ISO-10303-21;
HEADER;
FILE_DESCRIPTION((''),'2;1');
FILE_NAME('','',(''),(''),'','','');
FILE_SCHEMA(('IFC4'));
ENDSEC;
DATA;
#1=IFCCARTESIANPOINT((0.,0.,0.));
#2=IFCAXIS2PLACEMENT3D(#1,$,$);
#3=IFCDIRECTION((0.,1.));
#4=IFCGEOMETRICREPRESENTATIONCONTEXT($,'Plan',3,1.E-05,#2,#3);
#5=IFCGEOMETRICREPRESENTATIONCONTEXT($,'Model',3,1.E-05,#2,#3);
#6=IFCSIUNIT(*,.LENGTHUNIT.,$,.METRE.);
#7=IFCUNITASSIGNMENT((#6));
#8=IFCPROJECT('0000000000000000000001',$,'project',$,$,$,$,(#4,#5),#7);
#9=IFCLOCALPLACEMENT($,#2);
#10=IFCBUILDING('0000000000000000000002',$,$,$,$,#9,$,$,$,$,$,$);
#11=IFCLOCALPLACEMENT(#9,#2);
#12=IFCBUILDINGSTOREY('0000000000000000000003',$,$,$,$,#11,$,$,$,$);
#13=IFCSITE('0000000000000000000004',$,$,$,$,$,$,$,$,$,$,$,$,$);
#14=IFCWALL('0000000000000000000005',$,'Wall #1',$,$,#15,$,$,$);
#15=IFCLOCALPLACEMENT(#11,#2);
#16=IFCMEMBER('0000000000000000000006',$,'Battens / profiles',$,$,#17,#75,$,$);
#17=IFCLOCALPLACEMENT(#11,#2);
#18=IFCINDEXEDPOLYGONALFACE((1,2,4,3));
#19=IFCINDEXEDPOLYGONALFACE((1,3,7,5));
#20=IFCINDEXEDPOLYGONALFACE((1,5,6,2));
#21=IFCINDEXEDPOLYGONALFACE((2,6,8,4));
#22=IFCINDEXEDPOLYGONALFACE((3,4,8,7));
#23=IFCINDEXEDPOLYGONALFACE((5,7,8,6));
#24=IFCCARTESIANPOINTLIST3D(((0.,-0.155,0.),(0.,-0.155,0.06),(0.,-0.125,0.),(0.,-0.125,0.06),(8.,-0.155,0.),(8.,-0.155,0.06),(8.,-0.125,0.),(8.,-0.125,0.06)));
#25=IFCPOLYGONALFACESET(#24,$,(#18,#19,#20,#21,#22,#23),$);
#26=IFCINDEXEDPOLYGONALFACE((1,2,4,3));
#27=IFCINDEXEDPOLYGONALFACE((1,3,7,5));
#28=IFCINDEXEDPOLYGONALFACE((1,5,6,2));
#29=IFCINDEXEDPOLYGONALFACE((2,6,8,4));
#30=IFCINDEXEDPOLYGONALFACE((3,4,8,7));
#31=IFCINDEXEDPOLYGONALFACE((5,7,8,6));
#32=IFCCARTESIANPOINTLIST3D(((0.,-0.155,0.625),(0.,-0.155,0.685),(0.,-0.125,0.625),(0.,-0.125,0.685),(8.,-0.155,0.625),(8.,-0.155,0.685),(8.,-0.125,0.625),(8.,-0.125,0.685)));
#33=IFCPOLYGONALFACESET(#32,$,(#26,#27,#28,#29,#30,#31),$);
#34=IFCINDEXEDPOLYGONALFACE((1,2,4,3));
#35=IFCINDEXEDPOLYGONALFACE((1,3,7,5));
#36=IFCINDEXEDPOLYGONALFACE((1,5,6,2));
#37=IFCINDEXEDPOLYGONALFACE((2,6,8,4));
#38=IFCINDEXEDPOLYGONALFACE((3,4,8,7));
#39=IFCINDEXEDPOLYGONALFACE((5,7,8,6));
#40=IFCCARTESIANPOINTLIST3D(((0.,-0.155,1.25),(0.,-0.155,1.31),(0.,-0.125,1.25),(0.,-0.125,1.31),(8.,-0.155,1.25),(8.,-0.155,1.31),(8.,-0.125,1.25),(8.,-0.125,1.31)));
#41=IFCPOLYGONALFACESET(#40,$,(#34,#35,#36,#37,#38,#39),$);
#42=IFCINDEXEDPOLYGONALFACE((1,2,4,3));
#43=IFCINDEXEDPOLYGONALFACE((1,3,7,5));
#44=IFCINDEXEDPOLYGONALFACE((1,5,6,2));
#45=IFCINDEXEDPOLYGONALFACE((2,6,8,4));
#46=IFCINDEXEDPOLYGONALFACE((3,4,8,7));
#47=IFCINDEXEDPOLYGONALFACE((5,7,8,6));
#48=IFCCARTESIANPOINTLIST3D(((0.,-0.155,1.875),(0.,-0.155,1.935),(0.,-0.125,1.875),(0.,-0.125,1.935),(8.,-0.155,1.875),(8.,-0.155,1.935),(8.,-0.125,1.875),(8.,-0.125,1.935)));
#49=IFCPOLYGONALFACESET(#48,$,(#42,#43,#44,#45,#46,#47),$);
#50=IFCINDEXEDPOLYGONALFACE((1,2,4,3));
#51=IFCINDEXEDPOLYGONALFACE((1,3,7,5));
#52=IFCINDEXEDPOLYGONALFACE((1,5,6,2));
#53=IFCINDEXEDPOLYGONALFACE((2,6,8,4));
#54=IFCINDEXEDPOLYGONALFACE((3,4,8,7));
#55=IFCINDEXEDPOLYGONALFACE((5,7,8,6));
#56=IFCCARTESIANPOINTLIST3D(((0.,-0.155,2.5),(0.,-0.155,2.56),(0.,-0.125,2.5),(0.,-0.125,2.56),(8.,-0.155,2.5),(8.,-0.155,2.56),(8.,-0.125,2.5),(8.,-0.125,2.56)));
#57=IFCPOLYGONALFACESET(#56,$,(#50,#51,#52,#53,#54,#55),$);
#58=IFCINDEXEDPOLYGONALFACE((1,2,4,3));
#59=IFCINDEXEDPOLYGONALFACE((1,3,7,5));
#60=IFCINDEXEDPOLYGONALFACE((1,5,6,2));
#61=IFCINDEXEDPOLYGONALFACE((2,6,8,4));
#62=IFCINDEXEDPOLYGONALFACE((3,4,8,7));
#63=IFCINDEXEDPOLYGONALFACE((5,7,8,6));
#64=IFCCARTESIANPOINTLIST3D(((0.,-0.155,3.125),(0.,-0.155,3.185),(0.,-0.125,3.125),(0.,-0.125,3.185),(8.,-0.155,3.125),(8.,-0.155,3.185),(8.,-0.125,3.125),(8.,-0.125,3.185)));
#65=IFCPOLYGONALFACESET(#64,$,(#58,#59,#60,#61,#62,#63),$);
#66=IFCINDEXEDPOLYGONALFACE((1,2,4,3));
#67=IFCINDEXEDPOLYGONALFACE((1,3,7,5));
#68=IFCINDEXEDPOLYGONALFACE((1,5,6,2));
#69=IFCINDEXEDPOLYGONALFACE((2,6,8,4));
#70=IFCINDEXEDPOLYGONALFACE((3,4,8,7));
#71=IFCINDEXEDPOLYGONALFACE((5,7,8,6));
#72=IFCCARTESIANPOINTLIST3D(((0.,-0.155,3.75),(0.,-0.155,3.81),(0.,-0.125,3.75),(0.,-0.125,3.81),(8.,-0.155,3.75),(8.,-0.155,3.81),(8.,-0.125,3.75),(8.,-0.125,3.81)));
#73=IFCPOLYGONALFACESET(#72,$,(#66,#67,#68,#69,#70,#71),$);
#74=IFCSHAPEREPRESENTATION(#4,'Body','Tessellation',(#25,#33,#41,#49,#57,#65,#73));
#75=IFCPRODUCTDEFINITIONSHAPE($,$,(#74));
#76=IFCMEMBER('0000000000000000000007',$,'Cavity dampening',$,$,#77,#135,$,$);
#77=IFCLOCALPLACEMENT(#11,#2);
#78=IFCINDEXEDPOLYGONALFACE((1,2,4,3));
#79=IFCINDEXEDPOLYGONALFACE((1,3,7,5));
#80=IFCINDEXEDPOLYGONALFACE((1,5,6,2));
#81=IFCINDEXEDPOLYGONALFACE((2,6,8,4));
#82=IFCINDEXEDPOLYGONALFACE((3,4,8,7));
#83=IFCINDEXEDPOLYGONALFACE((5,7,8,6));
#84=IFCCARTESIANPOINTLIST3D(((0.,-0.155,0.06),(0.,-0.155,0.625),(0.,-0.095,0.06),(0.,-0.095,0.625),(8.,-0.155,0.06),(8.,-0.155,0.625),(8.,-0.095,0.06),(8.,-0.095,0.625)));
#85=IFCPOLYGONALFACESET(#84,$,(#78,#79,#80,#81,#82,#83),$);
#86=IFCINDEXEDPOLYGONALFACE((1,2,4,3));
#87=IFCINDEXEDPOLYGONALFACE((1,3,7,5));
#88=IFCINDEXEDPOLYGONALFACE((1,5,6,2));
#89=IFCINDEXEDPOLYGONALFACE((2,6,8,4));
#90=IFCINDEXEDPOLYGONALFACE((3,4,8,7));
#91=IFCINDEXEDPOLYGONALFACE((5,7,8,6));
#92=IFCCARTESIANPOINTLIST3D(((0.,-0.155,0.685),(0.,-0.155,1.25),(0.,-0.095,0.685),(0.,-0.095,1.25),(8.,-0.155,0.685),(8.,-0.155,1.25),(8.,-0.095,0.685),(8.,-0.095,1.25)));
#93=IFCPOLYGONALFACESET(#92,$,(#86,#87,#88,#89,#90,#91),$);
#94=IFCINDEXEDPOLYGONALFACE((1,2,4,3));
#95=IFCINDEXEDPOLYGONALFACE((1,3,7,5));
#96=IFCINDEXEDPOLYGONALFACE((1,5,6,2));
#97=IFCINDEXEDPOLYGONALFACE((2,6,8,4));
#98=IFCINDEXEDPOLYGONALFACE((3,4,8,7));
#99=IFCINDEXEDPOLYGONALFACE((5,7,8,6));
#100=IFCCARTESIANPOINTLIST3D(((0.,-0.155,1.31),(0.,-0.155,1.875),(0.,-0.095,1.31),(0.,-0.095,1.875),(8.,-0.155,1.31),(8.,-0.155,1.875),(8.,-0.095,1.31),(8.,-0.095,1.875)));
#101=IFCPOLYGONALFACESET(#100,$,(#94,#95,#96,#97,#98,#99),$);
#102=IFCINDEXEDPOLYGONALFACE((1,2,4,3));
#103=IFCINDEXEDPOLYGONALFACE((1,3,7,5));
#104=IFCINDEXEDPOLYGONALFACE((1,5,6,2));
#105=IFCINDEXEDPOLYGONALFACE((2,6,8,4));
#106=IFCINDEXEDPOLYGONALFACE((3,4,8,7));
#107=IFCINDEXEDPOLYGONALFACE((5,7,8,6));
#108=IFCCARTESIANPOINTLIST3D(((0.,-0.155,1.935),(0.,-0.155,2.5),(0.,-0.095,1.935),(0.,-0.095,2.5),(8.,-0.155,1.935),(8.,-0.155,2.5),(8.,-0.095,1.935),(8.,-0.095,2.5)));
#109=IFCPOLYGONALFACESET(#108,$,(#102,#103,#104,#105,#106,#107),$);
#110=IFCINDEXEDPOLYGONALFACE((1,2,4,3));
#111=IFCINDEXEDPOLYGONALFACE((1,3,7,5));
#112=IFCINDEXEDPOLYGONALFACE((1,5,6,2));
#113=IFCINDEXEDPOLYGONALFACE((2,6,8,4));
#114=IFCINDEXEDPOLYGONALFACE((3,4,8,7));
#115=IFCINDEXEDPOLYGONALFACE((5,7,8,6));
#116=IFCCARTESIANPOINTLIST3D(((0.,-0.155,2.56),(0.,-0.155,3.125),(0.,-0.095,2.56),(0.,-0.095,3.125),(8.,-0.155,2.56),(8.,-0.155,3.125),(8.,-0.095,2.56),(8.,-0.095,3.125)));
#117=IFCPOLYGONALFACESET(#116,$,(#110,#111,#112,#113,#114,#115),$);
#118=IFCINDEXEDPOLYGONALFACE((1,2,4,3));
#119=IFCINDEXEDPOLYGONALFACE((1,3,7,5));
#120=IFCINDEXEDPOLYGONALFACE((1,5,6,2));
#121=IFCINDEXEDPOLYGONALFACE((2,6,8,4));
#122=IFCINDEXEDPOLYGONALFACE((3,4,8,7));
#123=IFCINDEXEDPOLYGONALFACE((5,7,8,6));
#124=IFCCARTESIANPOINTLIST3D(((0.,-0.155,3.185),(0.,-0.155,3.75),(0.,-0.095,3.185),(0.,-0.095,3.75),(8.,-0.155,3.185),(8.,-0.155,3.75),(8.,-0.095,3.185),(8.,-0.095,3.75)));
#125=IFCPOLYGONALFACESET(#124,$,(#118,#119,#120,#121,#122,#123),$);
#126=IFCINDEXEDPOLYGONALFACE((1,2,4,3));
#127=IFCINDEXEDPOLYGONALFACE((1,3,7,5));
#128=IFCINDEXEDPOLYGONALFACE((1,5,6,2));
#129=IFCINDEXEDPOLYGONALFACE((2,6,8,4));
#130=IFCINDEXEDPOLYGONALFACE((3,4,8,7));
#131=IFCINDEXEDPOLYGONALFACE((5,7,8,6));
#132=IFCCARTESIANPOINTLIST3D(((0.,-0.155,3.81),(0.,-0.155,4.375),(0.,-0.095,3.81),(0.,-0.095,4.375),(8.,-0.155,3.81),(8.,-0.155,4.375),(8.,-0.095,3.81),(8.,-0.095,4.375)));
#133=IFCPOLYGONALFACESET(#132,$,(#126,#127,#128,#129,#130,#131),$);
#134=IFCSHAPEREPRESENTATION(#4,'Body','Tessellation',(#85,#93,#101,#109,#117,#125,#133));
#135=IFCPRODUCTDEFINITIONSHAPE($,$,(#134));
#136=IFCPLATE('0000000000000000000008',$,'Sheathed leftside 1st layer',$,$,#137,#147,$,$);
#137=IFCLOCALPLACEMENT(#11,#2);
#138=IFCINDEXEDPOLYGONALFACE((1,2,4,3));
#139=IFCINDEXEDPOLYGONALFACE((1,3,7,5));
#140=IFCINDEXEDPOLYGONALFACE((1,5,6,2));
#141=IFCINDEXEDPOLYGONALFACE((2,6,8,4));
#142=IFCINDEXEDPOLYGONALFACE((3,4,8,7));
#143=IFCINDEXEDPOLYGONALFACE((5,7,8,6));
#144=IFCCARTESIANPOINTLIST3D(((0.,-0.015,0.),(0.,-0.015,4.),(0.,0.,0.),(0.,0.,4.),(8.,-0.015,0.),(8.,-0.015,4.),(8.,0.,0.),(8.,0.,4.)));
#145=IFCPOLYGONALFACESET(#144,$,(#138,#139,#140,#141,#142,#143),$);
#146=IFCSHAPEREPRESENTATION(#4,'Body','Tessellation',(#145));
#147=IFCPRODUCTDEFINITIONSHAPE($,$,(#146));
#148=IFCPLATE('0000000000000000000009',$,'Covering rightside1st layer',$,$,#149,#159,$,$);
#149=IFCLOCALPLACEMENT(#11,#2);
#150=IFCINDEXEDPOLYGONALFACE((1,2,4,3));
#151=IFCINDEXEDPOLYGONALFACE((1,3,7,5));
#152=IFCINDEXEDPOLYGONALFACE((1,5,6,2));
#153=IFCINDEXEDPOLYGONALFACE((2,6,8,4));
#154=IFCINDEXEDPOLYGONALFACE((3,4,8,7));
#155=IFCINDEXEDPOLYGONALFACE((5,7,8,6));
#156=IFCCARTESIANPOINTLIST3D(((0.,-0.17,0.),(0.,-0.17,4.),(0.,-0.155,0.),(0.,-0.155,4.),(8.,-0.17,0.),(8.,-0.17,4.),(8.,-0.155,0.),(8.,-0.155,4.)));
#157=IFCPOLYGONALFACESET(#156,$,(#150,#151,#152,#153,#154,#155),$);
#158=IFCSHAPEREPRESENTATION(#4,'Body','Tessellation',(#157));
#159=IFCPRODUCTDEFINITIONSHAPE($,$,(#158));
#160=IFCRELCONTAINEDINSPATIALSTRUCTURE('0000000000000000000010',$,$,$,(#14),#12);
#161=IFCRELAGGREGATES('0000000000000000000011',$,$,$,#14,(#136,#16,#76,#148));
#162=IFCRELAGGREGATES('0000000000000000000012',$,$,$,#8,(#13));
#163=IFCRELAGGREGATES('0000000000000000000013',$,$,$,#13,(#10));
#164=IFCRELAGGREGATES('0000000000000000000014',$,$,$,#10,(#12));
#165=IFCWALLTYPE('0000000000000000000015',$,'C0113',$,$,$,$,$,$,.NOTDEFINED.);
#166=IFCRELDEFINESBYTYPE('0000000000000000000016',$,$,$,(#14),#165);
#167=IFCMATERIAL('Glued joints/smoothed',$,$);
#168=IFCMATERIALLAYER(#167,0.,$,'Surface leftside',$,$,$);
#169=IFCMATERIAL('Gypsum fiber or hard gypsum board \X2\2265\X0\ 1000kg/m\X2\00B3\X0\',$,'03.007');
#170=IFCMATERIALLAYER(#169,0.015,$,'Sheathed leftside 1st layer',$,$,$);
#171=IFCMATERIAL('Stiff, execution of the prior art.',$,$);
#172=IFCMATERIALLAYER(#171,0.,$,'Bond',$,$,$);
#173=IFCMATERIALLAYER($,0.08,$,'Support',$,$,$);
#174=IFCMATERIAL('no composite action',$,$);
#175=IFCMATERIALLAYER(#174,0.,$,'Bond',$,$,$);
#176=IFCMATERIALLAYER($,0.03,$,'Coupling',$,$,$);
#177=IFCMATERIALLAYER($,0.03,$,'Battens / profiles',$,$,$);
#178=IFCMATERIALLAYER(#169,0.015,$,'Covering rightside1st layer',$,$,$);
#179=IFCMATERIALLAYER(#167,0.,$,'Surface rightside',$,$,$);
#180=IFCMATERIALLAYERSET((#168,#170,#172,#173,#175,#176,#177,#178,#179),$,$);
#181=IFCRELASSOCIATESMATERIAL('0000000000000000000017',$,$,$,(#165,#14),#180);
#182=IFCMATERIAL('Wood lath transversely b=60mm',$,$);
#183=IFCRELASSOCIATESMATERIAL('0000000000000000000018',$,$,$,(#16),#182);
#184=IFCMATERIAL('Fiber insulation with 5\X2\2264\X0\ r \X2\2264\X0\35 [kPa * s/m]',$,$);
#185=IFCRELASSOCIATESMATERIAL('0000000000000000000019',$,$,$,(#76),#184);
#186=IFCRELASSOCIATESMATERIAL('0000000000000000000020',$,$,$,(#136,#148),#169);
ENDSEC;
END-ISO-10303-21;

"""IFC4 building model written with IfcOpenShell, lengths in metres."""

from ifc_helpers import new_model, si_unit, direction, frame, frame_2d, origin, origin_with_axes, place, context, project, spatial, rectangle, extrude, material, layer, layer_set, type_object, element, aggregate, save


model = new_model("IFC4")

# Units and contexts
plan_context = context("Plan", 3, precision=1e-05, world=origin(), true_north=direction((0.0, 1.0)))
model_context = context("Model", 3, precision=1e-05, world=origin(), true_north=direction((0.0, 1.0)))
ifc_project = project(units=[si_unit("LENGTHUNIT", "METRE")], contexts=[plan_context, model_context])

# Site, building, storey
site = spatial("IfcSite", under=ifc_project)
building_placement = place(None, origin())
building = spatial("IfcBuilding", under=site, at=building_placement)
storey_placement = place(building_placement, origin())
storey = spatial("IfcBuildingStorey", under=building, at=storey_placement)

# Wall, members, plates
ifc_material_1 = material(Name="Glued joints/smoothed")
ifc_layer_1 = layer(ifc_material_1, 0.0, Name="Surface leftside")
ifc_material_2 = material(Name="Gypsum fiber or hard gypsum board ≥ 1000kg/m³", Category="03.007")
ifc_layer_2 = layer(ifc_material_2, 0.015, Name="Sheathed leftside 1st layer")
ifc_material_3 = material(Name="Stiff, execution of the prior art.")
ifc_layer_3 = layer(ifc_material_3, 0.0, Name="Bond")
ifc_layer_4 = layer(None, 0.08, Name="Support")
ifc_material_4 = material(Name="no composite action")
ifc_layer_5 = layer(ifc_material_4, 0.0, Name="Bond")
ifc_layer_6 = layer(None, 0.03, Name="Coupling")
ifc_layer_7 = layer(None, 0.03, Name="Battens / profiles")
ifc_layer_8 = layer(ifc_material_2, 0.015, Name="Covering rightside1st layer")
ifc_layer_9 = layer(ifc_material_1, 0.0, Name="Surface rightside")
ifc_layer_set = layer_set([ifc_layer_1, ifc_layer_2, ifc_layer_3, ifc_layer_4, ifc_layer_5, ifc_layer_6, ifc_layer_7, ifc_layer_8, ifc_layer_9])
wall_type = type_object("IfcWallType", Name="C0113", PredefinedType="NOTDEFINED", material=ifc_layer_set)
wall_placement = place(None, frame((0.0, 0.0, 0.0), z_axis=(0.0, -1.0, 0.0), x_axis=(1.0, 0.0, 0.0)))
wall = element("IfcWall", 1, at=wall_placement, inside=storey, type_object=wall_type, material=ifc_layer_set, Name="Wall #1")
ifc_material_5 = material(Name="Wood lath transversely b=60mm")
member_1_placement = place(wall_placement, origin())
member_1 = element("IfcMember", 2, at=member_1_placement, material=ifc_material_5, Name="Battens / profiles", context=plan_context, shape_type="SweptSolid", body=[
    extrude(rectangle(XDim=0.06, YDim=0.03, at=frame_2d((0.03, 0.015), x_axis=(1.0, 0.0))), frame((0.0, 0.0, 0.125), z_axis=(1.0, 0.0, 0.0), x_axis=(0.0, 1.0, 0.0)), (0.0, 0.0, 1.0), 8.0),
    extrude(rectangle(XDim=0.06, YDim=0.03, at=frame_2d((0.03, 0.015), x_axis=(1.0, 0.0))), frame((0.0, 0.625, 0.125), z_axis=(1.0, 0.0, 0.0), x_axis=(0.0, 1.0, 0.0)), (0.0, 0.0, 1.0), 8.0),
    extrude(rectangle(XDim=0.06, YDim=0.03, at=frame_2d((0.03, 0.015), x_axis=(1.0, 0.0))), frame((0.0, 1.25, 0.125), z_axis=(1.0, 0.0, 0.0), x_axis=(0.0, 1.0, 0.0)), (0.0, 0.0, 1.0), 8.0),
    extrude(rectangle(XDim=0.06, YDim=0.03, at=frame_2d((0.03, 0.015), x_axis=(1.0, 0.0))), frame((0.0, 1.875, 0.125), z_axis=(1.0, 0.0, 0.0), x_axis=(0.0, 1.0, 0.0)), (0.0, 0.0, 1.0), 8.0),
    extrude(rectangle(XDim=0.06, YDim=0.03, at=frame_2d((0.03, 0.015), x_axis=(1.0, 0.0))), frame((0.0, 2.5, 0.125), z_axis=(1.0, 0.0, 0.0), x_axis=(0.0, 1.0, 0.0)), (0.0, 0.0, 1.0), 8.0),
    extrude(rectangle(XDim=0.06, YDim=0.03, at=frame_2d((0.03, 0.015), x_axis=(1.0, 0.0))), frame((0.0, 3.125, 0.125), z_axis=(1.0, 0.0, 0.0), x_axis=(0.0, 1.0, 0.0)), (0.0, 0.0, 1.0), 8.0),
    extrude(rectangle(XDim=0.06, YDim=0.03, at=frame_2d((0.03, 0.015), x_axis=(1.0, 0.0))), frame((0.0, 3.75, 0.125), z_axis=(1.0, 0.0, 0.0), x_axis=(0.0, 1.0, 0.0)), (0.0, 0.0, 1.0), 8.0),
])
ifc_material_6 = material(Name="Fiber insulation with 5≤ r ≤35 [kPa * s/m]")
member_2_placement = place(wall_placement, origin())
member_2 = element("IfcMember", 3, at=member_2_placement, material=ifc_material_6, Name="Cavity dampening", context=plan_context, shape_type="SweptSolid", body=[
    extrude(rectangle(XDim=0.565, YDim=0.06, at=frame_2d((0.2825, 0.03), x_axis=(1.0, 0.0))), frame((0.0, 0.06, 0.095), z_axis=(1.0, 0.0, 0.0), x_axis=(0.0, 1.0, 0.0)), (0.0, 0.0, 1.0), 8.0),
    extrude(rectangle(XDim=0.565, YDim=0.06, at=frame_2d((0.2825, 0.03), x_axis=(1.0, 0.0))), frame((0.0, 0.685, 0.095), z_axis=(1.0, 0.0, 0.0), x_axis=(0.0, 1.0, 0.0)), (0.0, 0.0, 1.0), 8.0),
    extrude(rectangle(XDim=0.565, YDim=0.06, at=frame_2d((0.2825, 0.03), x_axis=(1.0, 0.0))), frame((0.0, 1.31, 0.095), z_axis=(1.0, 0.0, 0.0), x_axis=(0.0, 1.0, 0.0)), (0.0, 0.0, 1.0), 8.0),
    extrude(rectangle(XDim=0.565, YDim=0.06, at=frame_2d((0.2825, 0.03), x_axis=(1.0, 0.0))), frame((0.0, 1.935, 0.095), z_axis=(1.0, 0.0, 0.0), x_axis=(0.0, 1.0, 0.0)), (0.0, 0.0, 1.0), 8.0),
    extrude(rectangle(XDim=0.565, YDim=0.06, at=frame_2d((0.2825, 0.03), x_axis=(1.0, 0.0))), frame((0.0, 2.56, 0.095), z_axis=(1.0, 0.0, 0.0), x_axis=(0.0, 1.0, 0.0)), (0.0, 0.0, 1.0), 8.0),
    extrude(rectangle(XDim=0.565, YDim=0.06, at=frame_2d((0.2825, 0.03), x_axis=(1.0, 0.0))), frame((0.0, 3.185, 0.095), z_axis=(1.0, 0.0, 0.0), x_axis=(0.0, 1.0, 0.0)), (0.0, 0.0, 1.0), 8.0),
    extrude(rectangle(XDim=0.565, YDim=0.06, at=frame_2d((0.2825, 0.03), x_axis=(1.0, 0.0))), frame((0.0, 3.81, 0.095), z_axis=(1.0, 0.0, 0.0), x_axis=(0.0, 1.0, 0.0)), (0.0, 0.0, 1.0), 8.0),
])
plate_1_placement = place(wall_placement, origin())
plate_1 = element("IfcPlate", 4, at=plate_1_placement, material=ifc_material_2, Name="Sheathed leftside 1st layer", context=plan_context, shape_type="SweptSolid", body=[
    extrude(rectangle(XDim=8.0, YDim=4.0, at=frame_2d((4.0, 2.0), x_axis=(1.0, 0.0))), origin_with_axes(), (0.0, 0.0, 1.0), 0.015),
])
plate_2_placement = place(wall_placement, origin())
plate_2 = element("IfcPlate", 5, at=plate_2_placement, material=ifc_material_2, Name="Covering rightside1st layer", context=plan_context, shape_type="SweptSolid", body=[
    extrude(rectangle(XDim=8.0, YDim=4.0, at=frame_2d((4.0, 2.0), x_axis=(1.0, 0.0))), frame((0.0, 0.0, 0.155), z_axis=(0.0, 0.0, 1.0), x_axis=(1.0, 0.0, 0.0)), (0.0, 0.0, 1.0), 0.015),
])
aggregate(wall, [plate_1, member_1, member_2, plate_2])

save(model, "model.ifc")
